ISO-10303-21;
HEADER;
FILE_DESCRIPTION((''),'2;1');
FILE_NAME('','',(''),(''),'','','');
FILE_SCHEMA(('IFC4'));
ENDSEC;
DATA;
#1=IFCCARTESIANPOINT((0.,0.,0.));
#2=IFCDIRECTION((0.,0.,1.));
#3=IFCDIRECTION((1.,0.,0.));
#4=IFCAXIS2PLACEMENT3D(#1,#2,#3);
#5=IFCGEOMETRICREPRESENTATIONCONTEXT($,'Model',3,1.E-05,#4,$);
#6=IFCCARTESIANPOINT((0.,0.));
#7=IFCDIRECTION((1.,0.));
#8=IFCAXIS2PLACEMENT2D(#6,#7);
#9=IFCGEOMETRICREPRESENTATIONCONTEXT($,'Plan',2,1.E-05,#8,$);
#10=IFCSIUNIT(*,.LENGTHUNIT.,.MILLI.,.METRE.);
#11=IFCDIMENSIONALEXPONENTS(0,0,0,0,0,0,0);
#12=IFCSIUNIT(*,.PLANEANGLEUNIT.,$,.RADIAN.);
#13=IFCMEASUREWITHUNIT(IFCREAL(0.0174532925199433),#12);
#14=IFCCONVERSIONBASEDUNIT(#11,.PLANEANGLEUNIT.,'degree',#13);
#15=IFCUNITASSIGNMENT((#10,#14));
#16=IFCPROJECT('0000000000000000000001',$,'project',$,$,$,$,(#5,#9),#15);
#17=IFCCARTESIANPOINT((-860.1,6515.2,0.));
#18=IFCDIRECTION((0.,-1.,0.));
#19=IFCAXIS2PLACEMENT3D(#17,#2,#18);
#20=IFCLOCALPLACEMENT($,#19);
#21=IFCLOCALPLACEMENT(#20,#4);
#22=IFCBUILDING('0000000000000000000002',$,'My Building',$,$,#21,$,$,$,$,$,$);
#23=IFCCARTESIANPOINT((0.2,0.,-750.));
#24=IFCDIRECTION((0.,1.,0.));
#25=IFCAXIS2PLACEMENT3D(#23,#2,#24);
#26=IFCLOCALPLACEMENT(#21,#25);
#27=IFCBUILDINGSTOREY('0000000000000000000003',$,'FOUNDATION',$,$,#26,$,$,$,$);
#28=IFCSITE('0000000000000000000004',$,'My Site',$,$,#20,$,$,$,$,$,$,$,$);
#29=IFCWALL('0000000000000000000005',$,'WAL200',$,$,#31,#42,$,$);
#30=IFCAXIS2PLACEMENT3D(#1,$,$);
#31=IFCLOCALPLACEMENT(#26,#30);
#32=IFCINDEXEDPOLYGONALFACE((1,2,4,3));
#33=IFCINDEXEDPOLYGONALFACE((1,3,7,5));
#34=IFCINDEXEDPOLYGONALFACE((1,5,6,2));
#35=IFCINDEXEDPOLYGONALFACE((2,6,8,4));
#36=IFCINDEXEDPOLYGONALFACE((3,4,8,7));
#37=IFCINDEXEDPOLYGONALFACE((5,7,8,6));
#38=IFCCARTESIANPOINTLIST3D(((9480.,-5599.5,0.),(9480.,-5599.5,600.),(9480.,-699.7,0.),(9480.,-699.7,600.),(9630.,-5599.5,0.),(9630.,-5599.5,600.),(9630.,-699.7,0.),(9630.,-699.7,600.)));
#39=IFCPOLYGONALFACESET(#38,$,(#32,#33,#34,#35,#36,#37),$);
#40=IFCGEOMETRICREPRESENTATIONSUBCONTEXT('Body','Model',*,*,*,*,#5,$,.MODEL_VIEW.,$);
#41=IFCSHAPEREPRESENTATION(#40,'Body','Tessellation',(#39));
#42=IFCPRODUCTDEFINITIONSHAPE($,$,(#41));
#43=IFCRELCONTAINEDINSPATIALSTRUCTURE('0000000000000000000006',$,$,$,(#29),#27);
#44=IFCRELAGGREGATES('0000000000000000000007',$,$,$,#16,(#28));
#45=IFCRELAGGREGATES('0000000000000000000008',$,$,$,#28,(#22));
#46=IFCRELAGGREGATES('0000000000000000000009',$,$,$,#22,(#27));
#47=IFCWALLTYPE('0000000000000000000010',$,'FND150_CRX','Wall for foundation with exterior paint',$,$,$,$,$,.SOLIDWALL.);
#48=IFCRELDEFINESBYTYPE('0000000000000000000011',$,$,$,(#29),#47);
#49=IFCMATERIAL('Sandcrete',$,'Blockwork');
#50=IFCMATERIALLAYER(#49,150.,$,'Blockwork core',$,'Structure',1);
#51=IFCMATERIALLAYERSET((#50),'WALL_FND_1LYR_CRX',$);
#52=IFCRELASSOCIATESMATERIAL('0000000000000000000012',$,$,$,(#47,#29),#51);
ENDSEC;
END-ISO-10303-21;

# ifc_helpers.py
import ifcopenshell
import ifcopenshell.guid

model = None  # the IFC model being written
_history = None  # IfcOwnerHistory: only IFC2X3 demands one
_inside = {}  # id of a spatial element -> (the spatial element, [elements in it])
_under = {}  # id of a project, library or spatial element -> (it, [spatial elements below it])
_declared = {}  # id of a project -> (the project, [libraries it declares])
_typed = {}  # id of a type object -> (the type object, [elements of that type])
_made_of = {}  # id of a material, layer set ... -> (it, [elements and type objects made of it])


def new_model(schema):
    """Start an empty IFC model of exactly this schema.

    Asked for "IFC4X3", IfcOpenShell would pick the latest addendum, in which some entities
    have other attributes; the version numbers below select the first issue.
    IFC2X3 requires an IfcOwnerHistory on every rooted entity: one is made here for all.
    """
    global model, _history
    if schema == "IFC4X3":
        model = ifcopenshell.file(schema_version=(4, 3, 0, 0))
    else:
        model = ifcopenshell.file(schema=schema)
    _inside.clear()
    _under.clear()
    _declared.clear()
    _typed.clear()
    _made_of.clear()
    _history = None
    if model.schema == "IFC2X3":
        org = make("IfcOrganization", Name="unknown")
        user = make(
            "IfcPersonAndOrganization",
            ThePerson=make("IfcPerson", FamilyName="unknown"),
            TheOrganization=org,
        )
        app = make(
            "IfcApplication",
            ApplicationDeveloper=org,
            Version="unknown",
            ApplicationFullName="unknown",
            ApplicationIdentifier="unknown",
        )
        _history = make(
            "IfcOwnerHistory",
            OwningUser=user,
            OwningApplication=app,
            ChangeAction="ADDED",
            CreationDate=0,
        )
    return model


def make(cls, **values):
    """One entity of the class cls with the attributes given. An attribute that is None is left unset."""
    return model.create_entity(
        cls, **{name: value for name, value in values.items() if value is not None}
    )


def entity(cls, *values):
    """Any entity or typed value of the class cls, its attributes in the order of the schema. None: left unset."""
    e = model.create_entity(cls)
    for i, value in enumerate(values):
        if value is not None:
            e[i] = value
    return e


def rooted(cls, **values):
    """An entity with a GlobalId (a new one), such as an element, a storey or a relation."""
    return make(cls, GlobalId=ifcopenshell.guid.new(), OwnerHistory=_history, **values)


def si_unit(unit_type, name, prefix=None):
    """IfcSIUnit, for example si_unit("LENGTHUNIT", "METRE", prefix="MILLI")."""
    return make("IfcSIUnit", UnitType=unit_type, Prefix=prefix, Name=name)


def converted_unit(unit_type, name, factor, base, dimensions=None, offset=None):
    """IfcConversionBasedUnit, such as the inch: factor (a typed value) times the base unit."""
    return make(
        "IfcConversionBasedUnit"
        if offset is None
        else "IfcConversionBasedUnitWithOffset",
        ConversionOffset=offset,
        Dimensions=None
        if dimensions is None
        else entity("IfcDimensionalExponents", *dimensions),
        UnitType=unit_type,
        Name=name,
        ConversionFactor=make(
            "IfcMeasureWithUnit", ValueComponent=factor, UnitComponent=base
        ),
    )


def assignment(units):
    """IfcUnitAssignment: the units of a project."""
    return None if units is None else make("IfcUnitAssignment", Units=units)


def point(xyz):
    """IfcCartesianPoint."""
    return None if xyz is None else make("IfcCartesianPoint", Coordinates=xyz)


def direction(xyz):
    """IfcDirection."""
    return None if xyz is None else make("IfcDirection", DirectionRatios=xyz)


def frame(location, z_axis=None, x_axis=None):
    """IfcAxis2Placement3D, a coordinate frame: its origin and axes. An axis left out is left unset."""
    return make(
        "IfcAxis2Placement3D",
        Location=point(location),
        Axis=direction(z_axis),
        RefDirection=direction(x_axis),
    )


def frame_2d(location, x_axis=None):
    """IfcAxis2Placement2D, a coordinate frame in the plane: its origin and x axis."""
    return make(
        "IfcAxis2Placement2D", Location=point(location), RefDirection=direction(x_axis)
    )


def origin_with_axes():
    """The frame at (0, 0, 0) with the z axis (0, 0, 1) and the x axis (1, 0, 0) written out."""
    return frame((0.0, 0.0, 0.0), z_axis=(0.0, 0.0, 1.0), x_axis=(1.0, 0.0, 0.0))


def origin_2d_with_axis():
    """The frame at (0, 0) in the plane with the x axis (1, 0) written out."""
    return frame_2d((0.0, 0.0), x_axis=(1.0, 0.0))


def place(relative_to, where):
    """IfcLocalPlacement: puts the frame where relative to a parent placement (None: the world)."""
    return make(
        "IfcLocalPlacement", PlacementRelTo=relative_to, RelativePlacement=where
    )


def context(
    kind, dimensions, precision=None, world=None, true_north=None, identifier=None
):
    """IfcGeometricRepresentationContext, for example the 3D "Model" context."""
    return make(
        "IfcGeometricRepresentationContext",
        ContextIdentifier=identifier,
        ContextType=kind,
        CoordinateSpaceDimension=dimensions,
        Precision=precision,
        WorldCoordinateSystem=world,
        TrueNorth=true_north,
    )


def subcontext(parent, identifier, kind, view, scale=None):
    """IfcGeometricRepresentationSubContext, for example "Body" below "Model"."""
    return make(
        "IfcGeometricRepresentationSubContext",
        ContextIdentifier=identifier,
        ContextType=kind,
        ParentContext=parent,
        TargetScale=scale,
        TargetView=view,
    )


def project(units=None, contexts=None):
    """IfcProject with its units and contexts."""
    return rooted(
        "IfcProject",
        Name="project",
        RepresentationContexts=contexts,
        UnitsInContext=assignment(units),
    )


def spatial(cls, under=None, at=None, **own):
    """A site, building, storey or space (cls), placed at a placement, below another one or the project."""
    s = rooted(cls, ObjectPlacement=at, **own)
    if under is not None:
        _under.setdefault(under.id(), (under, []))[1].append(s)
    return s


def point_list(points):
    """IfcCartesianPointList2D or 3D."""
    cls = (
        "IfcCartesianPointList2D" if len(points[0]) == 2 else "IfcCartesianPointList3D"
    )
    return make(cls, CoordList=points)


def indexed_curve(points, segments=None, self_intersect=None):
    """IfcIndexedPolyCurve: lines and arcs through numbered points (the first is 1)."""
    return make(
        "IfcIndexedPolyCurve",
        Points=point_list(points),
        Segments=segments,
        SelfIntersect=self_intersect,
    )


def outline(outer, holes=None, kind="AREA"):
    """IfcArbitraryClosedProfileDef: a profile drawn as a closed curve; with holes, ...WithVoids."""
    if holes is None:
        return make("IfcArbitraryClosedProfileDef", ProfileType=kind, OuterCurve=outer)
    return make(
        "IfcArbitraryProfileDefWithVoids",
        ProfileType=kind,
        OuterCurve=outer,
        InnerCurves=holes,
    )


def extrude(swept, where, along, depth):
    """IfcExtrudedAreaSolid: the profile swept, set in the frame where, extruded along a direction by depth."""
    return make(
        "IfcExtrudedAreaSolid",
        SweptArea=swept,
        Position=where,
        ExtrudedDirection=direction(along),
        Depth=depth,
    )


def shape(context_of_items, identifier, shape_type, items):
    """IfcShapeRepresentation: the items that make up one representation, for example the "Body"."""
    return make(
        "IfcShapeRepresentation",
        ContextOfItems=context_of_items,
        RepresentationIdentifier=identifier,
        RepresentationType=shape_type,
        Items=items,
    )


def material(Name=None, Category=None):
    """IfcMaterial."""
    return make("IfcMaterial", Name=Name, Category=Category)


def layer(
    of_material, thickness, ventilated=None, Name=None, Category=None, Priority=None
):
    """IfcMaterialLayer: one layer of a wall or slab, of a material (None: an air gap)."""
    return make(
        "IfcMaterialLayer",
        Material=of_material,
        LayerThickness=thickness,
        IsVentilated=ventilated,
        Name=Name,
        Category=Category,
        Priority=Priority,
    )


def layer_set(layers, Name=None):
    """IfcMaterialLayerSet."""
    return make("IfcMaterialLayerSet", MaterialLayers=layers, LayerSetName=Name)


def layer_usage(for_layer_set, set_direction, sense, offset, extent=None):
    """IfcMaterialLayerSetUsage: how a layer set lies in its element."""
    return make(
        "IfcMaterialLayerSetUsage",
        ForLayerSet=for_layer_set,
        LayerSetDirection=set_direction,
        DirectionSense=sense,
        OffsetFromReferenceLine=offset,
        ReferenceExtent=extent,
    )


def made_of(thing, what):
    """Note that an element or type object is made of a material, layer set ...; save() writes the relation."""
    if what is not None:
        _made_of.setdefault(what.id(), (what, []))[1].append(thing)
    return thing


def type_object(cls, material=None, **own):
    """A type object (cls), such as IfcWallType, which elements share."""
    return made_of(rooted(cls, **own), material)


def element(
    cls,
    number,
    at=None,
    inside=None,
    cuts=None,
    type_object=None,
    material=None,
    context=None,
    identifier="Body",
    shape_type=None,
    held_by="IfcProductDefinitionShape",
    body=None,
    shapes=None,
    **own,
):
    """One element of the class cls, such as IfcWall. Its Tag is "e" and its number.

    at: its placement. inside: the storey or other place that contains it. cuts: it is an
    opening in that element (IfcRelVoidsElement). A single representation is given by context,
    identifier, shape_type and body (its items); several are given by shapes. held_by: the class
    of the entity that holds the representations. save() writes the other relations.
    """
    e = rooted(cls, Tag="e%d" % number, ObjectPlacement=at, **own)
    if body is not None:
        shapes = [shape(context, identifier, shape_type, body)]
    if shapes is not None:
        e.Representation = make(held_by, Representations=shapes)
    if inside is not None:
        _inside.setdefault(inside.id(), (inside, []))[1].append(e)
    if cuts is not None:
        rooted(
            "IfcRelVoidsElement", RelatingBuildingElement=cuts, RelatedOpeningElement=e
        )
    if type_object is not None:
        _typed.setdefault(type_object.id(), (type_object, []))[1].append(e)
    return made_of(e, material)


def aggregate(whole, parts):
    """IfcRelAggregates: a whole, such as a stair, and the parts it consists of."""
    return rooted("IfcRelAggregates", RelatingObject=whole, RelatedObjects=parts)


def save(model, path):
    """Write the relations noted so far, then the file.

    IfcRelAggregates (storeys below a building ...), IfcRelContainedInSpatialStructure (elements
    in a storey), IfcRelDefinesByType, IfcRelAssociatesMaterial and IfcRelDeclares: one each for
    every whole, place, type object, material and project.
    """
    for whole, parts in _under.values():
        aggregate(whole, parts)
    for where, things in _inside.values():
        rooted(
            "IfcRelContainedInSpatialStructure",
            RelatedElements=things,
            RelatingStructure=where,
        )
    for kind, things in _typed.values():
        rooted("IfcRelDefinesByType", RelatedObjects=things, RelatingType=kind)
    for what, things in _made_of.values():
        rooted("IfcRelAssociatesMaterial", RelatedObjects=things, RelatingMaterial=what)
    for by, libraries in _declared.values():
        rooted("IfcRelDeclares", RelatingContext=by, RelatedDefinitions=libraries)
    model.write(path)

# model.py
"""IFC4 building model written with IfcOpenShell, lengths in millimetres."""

from ifc_helpers import new_model, entity, si_unit, converted_unit, frame, origin_with_axes, origin_2d_with_axis, place, context, subcontext, project, spatial, indexed_curve, outline, extrude, material, layer, layer_set, layer_usage, type_object, element, save


model = new_model("IFC4")

# Units and contexts
model_context = context("Model", 3, precision=1e-05, world=origin_with_axes())
plan_context = context("Plan", 2, precision=1e-05, world=origin_2d_with_axis())
body_context = subcontext(model_context, "Body", "Model", "MODEL_VIEW")
ifc_project = project(units=[si_unit("LENGTHUNIT", "METRE", prefix="MILLI"), converted_unit("PLANEANGLEUNIT", "degree", entity("IfcReal", 0.0174532925199433), si_unit("PLANEANGLEUNIT", "RADIAN"), dimensions=[0, 0, 0, 0, 0, 0, 0])], contexts=[model_context, plan_context])

# Site, building, storey
site_placement = place(None, frame((-860.1, 6515.2, 0.0), z_axis=(0.0, 0.0, 1.0), x_axis=(0.0, -1.0, 0.0)))
site = spatial("IfcSite", under=ifc_project, at=site_placement, Name="My Site")
building_placement = place(site_placement, frame((0.0, 0.0, 0.0), z_axis=(0.0, 0.0, 1.0), x_axis=(1.0, 0.0, 0.0)))
building = spatial("IfcBuilding", under=site, at=building_placement, Name="My Building")
storey_placement = place(building_placement, frame((0.2, 0.0, -750.0), z_axis=(0.0, 0.0, 1.0), x_axis=(0.0, 1.0, 0.0)))
storey = spatial("IfcBuildingStorey", under=building, at=storey_placement, Name="FOUNDATION")

# Wall
ifc_material_1 = material(Name="Sandcrete", Category="Blockwork")
ifc_layer_1 = layer(ifc_material_1, 150.0, Name="Blockwork core", Category="Structure", Priority=1)
ifc_layer_set_1 = layer_set([ifc_layer_1], Name="WALL_FND_1LYR_CRX")
wall_type = type_object("IfcWallType", Name="FND150_CRX", Description="Wall for foundation with exterior paint", PredefinedType="SOLIDWALL", material=ifc_layer_set_1)
ifc_layer_usage_1 = layer_usage(ifc_layer_set_1, "AXIS2", "POSITIVE", 0.0)
wall_1_placement = place(storey_placement, frame((9630.0, -5599.5, 0.0), z_axis=(0.0, 0.0, 1.0), x_axis=(0.000001, 1.0, 0.0)))
element("IfcWall", 1, at=wall_1_placement, inside=storey, type_object=wall_type, material=ifc_layer_usage_1, Name="WAL200", context=body_context, shape_type="SweptSolid", body=[
    extrude(outline(indexed_curve([(0.0, 0.0), (0.0, 150.0), (4899.8, 150.0), (4899.8, 0.0), (0.0, 0.0)], self_intersect=False)), origin_with_axes(), (0.0, 0.0, 1.0), 600.0),
])

save(model, "model.ifc")
